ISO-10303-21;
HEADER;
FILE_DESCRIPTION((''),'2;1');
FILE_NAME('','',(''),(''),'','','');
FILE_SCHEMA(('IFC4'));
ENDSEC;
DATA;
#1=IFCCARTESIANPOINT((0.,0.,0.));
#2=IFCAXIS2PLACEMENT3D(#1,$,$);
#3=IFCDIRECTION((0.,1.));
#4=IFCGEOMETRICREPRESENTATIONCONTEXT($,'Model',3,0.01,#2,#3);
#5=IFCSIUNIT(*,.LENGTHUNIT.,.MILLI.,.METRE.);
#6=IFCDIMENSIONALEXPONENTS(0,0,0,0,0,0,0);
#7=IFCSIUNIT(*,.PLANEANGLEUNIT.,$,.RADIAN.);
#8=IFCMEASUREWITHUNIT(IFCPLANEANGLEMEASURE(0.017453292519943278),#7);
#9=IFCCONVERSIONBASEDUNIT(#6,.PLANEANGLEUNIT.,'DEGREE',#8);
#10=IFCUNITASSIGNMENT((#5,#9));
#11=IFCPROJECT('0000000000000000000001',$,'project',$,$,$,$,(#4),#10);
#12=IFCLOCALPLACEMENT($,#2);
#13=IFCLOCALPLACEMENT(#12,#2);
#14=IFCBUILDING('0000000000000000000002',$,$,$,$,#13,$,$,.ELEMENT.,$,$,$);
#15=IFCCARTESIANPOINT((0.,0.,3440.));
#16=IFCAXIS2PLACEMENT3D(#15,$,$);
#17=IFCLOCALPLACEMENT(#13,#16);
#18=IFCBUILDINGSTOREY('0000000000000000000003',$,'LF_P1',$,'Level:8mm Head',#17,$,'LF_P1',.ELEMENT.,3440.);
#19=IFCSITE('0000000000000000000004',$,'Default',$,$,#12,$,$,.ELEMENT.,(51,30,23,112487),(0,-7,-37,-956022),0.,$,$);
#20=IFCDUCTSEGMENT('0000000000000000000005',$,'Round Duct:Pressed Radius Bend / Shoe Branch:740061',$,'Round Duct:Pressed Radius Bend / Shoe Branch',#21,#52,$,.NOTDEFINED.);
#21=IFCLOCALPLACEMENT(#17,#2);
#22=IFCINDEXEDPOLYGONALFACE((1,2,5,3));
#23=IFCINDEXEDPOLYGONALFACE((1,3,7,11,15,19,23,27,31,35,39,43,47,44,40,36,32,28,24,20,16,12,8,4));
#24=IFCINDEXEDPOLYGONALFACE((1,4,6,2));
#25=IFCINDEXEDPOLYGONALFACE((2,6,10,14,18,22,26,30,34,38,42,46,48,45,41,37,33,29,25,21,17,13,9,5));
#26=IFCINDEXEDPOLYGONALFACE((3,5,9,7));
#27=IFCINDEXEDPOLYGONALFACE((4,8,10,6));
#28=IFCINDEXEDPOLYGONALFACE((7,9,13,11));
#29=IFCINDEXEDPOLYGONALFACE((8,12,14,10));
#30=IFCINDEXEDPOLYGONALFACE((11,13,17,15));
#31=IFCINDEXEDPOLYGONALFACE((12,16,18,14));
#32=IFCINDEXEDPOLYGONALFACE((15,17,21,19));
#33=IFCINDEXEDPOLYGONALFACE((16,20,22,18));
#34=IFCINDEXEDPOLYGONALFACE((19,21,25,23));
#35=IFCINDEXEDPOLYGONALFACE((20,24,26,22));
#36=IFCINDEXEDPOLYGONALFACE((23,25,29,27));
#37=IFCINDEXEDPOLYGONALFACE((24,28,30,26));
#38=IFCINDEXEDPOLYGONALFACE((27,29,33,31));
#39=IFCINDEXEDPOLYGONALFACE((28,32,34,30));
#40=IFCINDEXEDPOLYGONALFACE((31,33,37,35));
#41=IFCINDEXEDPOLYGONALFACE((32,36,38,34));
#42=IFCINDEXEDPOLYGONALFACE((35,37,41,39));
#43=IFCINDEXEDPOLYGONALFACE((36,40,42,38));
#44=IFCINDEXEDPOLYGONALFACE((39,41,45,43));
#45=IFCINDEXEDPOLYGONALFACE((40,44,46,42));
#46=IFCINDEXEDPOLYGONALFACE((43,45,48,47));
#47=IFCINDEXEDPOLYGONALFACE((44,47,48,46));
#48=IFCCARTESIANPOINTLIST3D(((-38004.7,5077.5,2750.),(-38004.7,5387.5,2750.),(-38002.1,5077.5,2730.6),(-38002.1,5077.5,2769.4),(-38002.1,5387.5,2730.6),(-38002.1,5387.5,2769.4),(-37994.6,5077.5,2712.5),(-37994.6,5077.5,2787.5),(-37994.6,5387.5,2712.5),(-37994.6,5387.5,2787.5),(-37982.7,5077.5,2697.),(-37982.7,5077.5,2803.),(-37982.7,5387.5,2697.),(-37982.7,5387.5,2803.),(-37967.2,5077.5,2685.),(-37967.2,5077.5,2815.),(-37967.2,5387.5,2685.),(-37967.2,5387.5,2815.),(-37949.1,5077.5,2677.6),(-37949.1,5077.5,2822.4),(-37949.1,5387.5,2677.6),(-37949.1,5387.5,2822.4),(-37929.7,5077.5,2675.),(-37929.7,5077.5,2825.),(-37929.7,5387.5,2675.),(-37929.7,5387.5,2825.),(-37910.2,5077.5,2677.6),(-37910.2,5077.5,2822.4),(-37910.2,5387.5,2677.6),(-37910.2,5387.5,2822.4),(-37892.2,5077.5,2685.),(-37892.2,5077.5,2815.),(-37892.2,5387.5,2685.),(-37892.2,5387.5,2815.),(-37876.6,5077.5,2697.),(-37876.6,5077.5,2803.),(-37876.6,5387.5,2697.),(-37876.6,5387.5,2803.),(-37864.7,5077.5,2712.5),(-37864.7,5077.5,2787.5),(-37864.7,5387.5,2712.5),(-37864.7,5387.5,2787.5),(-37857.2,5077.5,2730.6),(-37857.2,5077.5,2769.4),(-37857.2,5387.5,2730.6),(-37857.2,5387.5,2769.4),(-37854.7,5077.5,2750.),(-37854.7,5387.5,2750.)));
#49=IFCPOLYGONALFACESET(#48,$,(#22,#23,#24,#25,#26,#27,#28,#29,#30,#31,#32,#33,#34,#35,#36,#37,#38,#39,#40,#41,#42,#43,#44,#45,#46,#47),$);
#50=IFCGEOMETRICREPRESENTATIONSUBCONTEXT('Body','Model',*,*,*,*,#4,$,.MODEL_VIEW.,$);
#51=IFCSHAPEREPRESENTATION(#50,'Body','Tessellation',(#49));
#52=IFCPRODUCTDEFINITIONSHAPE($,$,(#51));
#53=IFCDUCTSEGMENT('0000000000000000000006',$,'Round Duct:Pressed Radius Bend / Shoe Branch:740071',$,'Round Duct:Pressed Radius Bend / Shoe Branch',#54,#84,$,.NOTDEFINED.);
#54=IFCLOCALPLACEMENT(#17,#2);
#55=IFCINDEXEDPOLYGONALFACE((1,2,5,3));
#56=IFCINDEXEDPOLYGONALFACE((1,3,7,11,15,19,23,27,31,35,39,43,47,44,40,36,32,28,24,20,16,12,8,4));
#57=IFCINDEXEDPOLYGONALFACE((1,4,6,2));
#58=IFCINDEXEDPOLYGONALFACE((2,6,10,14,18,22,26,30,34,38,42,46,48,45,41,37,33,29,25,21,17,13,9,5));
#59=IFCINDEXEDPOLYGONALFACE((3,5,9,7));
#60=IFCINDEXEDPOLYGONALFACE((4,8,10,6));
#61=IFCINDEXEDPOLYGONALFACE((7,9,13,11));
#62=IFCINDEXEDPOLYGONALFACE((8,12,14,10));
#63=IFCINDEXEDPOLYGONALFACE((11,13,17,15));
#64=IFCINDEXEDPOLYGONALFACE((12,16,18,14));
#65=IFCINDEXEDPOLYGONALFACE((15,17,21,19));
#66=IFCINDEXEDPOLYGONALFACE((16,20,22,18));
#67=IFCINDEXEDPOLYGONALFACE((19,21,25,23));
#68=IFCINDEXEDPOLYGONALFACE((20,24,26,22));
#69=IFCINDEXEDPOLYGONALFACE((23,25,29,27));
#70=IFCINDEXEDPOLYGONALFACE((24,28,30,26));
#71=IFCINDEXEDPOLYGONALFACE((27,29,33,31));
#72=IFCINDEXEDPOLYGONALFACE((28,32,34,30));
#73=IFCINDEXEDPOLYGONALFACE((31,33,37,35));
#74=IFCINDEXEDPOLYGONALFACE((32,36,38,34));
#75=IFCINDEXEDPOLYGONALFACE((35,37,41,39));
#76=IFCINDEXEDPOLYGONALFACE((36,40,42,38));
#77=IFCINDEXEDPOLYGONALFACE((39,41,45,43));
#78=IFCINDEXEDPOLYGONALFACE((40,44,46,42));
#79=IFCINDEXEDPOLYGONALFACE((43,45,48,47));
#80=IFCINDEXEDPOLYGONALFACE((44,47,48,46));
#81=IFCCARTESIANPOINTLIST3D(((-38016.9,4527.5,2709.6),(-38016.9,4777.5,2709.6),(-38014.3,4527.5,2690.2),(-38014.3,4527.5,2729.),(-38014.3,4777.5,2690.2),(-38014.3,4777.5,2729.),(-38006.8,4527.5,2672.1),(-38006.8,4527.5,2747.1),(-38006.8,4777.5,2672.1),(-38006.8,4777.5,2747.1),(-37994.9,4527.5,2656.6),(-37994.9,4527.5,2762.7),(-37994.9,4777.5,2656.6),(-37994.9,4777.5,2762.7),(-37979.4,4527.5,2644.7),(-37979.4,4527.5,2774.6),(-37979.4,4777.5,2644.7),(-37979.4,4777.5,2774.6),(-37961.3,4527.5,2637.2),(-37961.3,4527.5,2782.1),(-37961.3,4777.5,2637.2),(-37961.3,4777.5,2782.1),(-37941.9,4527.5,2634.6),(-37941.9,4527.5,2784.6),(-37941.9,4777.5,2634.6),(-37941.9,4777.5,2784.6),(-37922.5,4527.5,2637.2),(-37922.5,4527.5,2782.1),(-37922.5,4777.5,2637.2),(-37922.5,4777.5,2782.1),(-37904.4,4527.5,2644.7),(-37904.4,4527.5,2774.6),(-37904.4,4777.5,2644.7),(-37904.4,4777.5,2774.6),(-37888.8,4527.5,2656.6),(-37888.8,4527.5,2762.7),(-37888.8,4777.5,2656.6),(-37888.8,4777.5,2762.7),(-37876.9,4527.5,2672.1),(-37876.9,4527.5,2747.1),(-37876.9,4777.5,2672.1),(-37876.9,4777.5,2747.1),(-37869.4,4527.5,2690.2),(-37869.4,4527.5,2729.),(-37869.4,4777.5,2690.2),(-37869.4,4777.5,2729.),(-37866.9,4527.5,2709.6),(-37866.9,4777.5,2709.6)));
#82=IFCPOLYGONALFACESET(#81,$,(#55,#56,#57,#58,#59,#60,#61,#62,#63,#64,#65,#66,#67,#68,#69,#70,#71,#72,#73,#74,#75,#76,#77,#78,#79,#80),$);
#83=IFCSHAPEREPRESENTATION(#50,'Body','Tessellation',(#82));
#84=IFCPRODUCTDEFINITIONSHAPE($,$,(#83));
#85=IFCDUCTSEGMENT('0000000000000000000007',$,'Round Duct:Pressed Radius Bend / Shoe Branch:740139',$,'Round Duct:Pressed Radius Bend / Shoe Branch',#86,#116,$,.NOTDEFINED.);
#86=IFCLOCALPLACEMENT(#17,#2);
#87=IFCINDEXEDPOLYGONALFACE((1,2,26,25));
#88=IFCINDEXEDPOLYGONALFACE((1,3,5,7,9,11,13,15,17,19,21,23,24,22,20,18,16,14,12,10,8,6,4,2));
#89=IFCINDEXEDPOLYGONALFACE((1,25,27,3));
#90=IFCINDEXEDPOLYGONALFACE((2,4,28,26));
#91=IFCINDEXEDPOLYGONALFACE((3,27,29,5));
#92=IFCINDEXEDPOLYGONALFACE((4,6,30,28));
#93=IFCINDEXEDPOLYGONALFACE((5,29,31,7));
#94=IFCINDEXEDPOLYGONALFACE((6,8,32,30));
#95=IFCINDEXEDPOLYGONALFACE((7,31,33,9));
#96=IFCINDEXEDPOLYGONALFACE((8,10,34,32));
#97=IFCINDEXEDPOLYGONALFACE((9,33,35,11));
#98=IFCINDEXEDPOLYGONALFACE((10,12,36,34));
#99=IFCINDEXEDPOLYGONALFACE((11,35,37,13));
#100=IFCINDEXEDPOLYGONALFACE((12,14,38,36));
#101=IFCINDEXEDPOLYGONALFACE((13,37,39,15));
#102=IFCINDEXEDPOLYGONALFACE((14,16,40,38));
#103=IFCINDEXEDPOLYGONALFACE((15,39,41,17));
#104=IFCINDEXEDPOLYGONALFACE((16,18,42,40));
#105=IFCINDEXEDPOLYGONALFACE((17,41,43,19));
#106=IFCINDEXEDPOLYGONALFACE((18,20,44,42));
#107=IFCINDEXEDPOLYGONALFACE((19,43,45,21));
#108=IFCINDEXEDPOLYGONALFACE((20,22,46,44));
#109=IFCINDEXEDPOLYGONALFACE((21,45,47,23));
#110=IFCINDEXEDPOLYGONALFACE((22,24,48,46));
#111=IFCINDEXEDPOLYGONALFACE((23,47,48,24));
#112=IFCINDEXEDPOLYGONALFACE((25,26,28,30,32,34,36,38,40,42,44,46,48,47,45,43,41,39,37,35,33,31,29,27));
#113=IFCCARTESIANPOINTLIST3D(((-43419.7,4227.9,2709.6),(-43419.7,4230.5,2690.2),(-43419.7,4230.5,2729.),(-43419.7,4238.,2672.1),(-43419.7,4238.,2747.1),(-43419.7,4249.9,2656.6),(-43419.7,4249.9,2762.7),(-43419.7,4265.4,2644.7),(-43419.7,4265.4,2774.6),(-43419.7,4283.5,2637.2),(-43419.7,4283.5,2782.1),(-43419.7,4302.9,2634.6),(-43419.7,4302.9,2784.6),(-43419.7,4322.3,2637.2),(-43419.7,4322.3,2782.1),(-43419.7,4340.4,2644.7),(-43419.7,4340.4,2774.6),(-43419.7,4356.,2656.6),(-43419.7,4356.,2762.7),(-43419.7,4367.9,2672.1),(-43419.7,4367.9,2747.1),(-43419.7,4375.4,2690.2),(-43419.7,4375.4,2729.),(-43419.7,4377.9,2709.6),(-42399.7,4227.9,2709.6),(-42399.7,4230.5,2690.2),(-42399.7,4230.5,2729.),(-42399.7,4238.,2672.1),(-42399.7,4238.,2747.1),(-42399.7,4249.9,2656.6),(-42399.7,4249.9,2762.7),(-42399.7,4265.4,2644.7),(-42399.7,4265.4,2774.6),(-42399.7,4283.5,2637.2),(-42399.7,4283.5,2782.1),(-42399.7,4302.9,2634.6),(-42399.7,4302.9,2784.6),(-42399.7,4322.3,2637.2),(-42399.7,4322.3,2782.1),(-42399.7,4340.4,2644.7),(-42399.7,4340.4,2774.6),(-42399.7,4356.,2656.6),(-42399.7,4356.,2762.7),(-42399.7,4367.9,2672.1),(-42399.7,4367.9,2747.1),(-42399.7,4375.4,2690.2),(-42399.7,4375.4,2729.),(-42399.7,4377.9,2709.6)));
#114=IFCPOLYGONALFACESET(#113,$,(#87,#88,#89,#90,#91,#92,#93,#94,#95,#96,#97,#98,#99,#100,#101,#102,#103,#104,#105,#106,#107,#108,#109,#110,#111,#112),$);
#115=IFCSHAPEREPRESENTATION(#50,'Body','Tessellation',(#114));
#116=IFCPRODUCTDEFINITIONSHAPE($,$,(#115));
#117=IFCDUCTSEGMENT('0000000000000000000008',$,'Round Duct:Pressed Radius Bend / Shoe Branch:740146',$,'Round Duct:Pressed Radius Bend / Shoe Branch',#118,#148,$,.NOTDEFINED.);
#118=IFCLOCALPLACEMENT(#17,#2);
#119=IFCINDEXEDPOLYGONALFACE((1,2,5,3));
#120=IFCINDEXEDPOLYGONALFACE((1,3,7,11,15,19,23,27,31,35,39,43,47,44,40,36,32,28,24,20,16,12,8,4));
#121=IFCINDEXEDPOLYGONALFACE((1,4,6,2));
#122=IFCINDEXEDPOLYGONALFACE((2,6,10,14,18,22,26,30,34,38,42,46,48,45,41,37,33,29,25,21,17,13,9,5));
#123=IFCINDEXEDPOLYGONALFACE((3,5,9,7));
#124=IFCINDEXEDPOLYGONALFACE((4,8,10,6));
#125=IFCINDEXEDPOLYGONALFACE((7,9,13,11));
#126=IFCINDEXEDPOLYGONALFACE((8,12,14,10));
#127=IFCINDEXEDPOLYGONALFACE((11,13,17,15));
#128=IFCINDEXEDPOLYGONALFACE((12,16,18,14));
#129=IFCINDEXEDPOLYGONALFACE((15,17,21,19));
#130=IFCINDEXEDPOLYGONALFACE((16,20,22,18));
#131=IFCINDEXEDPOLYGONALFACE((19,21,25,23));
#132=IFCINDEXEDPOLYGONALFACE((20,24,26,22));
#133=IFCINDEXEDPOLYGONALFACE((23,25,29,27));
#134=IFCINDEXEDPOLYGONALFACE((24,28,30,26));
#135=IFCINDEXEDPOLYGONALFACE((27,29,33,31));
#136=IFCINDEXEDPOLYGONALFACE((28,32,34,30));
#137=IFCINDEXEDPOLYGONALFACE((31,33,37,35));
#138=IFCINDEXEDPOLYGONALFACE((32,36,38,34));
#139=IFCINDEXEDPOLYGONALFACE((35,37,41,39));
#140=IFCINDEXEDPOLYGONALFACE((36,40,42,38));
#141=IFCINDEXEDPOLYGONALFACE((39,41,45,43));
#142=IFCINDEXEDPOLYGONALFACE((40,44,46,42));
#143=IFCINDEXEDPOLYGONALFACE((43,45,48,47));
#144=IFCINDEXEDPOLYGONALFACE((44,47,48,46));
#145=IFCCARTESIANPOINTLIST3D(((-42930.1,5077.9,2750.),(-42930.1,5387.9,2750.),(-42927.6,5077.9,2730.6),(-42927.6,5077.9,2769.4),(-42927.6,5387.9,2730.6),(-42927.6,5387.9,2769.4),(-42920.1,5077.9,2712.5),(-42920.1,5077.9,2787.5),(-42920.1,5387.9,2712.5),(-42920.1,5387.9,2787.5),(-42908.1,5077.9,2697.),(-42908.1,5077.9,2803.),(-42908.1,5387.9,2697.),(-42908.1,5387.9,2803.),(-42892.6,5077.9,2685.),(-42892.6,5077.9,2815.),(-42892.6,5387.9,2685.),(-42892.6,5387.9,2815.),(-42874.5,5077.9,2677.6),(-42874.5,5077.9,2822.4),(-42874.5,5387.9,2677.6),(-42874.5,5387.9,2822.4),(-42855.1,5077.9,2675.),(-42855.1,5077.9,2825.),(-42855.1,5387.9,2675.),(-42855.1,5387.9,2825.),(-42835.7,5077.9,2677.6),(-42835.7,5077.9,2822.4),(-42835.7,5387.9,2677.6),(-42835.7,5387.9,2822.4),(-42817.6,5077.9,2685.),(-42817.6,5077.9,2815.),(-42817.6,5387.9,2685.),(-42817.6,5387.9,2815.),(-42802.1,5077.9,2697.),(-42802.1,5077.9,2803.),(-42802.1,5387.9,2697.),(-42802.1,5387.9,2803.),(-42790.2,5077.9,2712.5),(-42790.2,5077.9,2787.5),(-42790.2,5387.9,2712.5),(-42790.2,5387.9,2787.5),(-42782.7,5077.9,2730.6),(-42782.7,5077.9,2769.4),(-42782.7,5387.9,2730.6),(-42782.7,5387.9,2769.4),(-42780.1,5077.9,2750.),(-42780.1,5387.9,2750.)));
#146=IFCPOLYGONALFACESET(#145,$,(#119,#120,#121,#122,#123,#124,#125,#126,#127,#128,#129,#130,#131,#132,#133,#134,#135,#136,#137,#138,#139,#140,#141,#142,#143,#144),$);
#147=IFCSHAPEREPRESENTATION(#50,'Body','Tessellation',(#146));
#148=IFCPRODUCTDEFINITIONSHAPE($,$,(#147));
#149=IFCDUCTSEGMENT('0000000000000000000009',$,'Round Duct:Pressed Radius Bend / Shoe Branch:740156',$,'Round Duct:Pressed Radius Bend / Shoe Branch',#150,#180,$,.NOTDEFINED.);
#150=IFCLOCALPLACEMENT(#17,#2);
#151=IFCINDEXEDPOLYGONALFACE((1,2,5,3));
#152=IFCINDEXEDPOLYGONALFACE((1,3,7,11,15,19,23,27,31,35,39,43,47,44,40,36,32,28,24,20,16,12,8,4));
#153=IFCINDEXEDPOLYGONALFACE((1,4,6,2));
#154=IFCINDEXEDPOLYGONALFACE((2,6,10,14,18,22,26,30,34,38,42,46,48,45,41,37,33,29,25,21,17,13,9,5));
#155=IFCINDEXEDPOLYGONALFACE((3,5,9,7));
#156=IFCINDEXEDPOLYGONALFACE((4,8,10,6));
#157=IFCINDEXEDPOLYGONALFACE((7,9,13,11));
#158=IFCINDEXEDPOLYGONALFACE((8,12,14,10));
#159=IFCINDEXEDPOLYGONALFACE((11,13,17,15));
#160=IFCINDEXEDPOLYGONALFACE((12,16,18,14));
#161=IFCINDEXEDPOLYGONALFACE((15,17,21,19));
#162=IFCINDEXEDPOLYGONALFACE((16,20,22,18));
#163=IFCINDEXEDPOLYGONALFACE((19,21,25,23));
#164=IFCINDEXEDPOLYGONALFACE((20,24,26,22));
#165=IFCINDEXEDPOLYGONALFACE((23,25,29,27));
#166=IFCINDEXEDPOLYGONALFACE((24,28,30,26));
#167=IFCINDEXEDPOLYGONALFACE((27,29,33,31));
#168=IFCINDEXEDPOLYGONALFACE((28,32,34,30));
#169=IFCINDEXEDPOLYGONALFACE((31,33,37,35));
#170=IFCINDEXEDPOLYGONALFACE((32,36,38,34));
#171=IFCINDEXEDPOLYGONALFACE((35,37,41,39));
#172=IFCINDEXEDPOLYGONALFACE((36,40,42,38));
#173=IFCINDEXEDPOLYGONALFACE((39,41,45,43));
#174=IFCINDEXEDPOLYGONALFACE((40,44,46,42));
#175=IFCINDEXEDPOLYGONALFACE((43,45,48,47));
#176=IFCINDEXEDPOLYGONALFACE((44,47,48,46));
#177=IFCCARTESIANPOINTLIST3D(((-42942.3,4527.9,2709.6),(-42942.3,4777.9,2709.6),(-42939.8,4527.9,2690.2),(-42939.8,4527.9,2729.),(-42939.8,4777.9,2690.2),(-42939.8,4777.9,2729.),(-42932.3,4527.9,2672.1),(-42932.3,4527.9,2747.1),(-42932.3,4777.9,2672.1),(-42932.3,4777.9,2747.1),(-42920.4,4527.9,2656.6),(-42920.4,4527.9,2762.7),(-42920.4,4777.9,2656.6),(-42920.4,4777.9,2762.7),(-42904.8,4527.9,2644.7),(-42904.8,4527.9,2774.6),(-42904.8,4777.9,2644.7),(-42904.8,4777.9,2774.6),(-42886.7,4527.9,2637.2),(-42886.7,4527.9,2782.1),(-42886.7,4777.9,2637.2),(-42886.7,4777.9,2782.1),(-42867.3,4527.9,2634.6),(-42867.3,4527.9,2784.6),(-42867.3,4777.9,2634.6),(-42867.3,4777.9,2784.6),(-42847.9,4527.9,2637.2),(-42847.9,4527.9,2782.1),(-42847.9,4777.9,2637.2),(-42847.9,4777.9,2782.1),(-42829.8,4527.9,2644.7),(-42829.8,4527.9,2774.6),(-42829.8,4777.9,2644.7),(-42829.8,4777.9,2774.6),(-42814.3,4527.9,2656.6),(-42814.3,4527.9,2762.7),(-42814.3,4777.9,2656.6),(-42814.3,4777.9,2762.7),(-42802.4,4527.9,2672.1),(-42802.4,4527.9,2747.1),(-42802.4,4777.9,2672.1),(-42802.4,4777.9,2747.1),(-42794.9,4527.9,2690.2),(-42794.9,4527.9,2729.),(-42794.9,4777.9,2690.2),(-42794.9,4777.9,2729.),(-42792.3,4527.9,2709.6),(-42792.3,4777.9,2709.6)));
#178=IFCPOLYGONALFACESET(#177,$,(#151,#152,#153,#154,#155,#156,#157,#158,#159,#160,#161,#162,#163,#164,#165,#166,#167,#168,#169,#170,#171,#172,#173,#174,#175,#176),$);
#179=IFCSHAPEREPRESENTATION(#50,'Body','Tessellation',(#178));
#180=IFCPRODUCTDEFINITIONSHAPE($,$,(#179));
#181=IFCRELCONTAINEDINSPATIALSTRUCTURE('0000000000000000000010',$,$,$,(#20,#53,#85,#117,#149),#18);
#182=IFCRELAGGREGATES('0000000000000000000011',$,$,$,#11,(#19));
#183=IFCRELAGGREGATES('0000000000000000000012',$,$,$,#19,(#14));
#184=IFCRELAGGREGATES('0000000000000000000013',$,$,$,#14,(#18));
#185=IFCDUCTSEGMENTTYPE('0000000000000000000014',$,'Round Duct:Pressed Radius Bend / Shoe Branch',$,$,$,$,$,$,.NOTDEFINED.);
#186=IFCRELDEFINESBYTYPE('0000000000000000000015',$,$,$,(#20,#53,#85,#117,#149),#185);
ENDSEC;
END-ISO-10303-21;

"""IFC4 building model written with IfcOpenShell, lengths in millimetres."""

from ifc_helpers import new_model, entity, si_unit, converted_unit, direction, frame, origin, place, context, subcontext, project, spatial, arc, indexed_curve, outline, extrude, type_object, element, save


model = new_model("IFC4")

# Units and contexts
model_context = context("Model", 3, precision=0.01, world=origin(), true_north=direction((0.0, 1.0)))
body_context = subcontext(model_context, "Body", "Model", "MODEL_VIEW")
ifc_project = project(units=[si_unit("LENGTHUNIT", "METRE", prefix="MILLI"), converted_unit("PLANEANGLEUNIT", "DEGREE", entity("IfcPlaneAngleMeasure", 0.017453292519943278), si_unit("PLANEANGLEUNIT", "RADIAN"), dimensions=[0, 0, 0, 0, 0, 0, 0])], contexts=[model_context])

# Site, building, storey
site_placement = place(None, origin())
site = spatial("IfcSite", under=ifc_project, at=site_placement, Name="Default", CompositionType="ELEMENT", RefLatitude=(51, 30, 23, 112487), RefLongitude=(0, -7, -37, -956022), RefElevation=0.0)
building_placement = place(site_placement, origin())
building = spatial("IfcBuilding", under=site, at=building_placement, CompositionType="ELEMENT")
storey_placement = place(building_placement, frame((0.0, 0.0, 3440.0)))
storey = spatial("IfcBuildingStorey", under=building, at=storey_placement, Name="LF_P1", ObjectType="Level:8mm Head", LongName="LF_P1", CompositionType="ELEMENT", Elevation=3440.0)

# Duct segments
duct_segment_type_1 = type_object("IfcDuctSegmentType", Name="Round Duct:Pressed Radius Bend / Shoe Branch", PredefinedType="NOTDEFINED")
duct_segment_1_placement = place(storey_placement, origin())
element("IfcDuctSegment", 1, at=duct_segment_1_placement, inside=storey, type_object=duct_segment_type_1, Name="Round Duct:Pressed Radius Bend / Shoe Branch:740061", ObjectType="Round Duct:Pressed Radius Bend / Shoe Branch", PredefinedType="NOTDEFINED", context=body_context, shape_type="SweptSolid", body=[
    extrude(outline(indexed_curve([(75.0, 0.0), (53.0, 53.0), (0.0, 75.0), (-53.0, 53.0), (-75.0, 0.0), (-53.0, -53.0), (0.0, -75.0), (53.0, -53.0)], segments=[arc(1, 2, 3), arc(3, 4, 5), arc(5, 6, 7), arc(7, 8, 1)], self_intersect=False)), frame((-37929.7, 5077.5, 2750.0), z_axis=(0.0, 1.0, 0.0), x_axis=(-1.0, 0.0, 0.0)), (0.0, 0.0, 1.0), 310.0),
])
duct_segment_2_placement = place(storey_placement, origin())
element("IfcDuctSegment", 2, at=duct_segment_2_placement, inside=storey, type_object=duct_segment_type_1, Name="Round Duct:Pressed Radius Bend / Shoe Branch:740071", ObjectType="Round Duct:Pressed Radius Bend / Shoe Branch", PredefinedType="NOTDEFINED", context=body_context, shape_type="SweptSolid", body=[
    extrude(outline(indexed_curve([(75.0, 0.0), (53.0, 53.0), (0.0, 75.0), (-53.0, 53.0), (-75.0, 0.0), (-53.0, -53.0), (0.0, -75.0), (53.0, -53.0)], segments=[arc(1, 2, 3), arc(3, 4, 5), arc(5, 6, 7), arc(7, 8, 1)], self_intersect=False)), frame((-37941.9, 4527.5, 2709.6), z_axis=(0.0, 1.0, 0.0), x_axis=(1.0, 0.0, 0.0)), (0.0, 0.0, 1.0), 250.0),
])
duct_segment_3_placement = place(storey_placement, origin())
element("IfcDuctSegment", 3, at=duct_segment_3_placement, inside=storey, type_object=duct_segment_type_1, Name="Round Duct:Pressed Radius Bend / Shoe Branch:740139", ObjectType="Round Duct:Pressed Radius Bend / Shoe Branch", PredefinedType="NOTDEFINED", context=body_context, shape_type="SweptSolid", body=[
    extrude(outline(indexed_curve([(75.0, 0.0), (53.0, 53.0), (0.0, 75.0), (-53.0, 53.0), (-75.0, 0.0), (-53.0, -53.0), (0.0, -75.0), (53.0, -53.0)], segments=[arc(1, 2, 3), arc(3, 4, 5), arc(5, 6, 7), arc(7, 8, 1)], self_intersect=False)), frame((-43419.7, 4302.9, 2709.6), z_axis=(1.0, 0.0, 0.0), x_axis=(0.0, 1.0, 0.0)), (0.0, 0.0, 1.0), 1020.0),
])
duct_segment_4_placement = place(storey_placement, origin())
element("IfcDuctSegment", 4, at=duct_segment_4_placement, inside=storey, type_object=duct_segment_type_1, Name="Round Duct:Pressed Radius Bend / Shoe Branch:740146", ObjectType="Round Duct:Pressed Radius Bend / Shoe Branch", PredefinedType="NOTDEFINED", context=body_context, shape_type="SweptSolid", body=[
    extrude(outline(indexed_curve([(75.0, 0.0), (53.0, 53.0), (0.0, 75.0), (-53.0, 53.0), (-75.0, 0.0), (-53.0, -53.0), (0.0, -75.0), (53.0, -53.0)], segments=[arc(1, 2, 3), arc(3, 4, 5), arc(5, 6, 7), arc(7, 8, 1)], self_intersect=False)), frame((-42855.1, 5077.9, 2750.0), z_axis=(0.0, 1.0, 0.0), x_axis=(-1.0, 0.0, 0.0)), (0.0, 0.0, 1.0), 310.0),
])
duct_segment_5_placement = place(storey_placement, origin())
element("IfcDuctSegment", 5, at=duct_segment_5_placement, inside=storey, type_object=duct_segment_type_1, Name="Round Duct:Pressed Radius Bend / Shoe Branch:740156", ObjectType="Round Duct:Pressed Radius Bend / Shoe Branch", PredefinedType="NOTDEFINED", context=body_context, shape_type="SweptSolid", body=[
    extrude(outline(indexed_curve([(75.0, 0.0), (53.0, 53.0), (0.0, 75.0), (-53.0, 53.0), (-75.0, 0.0), (-53.0, -53.0), (0.0, -75.0), (53.0, -53.0)], segments=[arc(1, 2, 3), arc(3, 4, 5), arc(5, 6, 7), arc(7, 8, 1)], self_intersect=False)), frame((-42867.3, 4527.9, 2709.6), z_axis=(0.0, 1.0, 0.0), x_axis=(1.0, 0.0, 0.0)), (0.0, 0.0, 1.0), 250.0),
])

save(model, "model.ifc")
